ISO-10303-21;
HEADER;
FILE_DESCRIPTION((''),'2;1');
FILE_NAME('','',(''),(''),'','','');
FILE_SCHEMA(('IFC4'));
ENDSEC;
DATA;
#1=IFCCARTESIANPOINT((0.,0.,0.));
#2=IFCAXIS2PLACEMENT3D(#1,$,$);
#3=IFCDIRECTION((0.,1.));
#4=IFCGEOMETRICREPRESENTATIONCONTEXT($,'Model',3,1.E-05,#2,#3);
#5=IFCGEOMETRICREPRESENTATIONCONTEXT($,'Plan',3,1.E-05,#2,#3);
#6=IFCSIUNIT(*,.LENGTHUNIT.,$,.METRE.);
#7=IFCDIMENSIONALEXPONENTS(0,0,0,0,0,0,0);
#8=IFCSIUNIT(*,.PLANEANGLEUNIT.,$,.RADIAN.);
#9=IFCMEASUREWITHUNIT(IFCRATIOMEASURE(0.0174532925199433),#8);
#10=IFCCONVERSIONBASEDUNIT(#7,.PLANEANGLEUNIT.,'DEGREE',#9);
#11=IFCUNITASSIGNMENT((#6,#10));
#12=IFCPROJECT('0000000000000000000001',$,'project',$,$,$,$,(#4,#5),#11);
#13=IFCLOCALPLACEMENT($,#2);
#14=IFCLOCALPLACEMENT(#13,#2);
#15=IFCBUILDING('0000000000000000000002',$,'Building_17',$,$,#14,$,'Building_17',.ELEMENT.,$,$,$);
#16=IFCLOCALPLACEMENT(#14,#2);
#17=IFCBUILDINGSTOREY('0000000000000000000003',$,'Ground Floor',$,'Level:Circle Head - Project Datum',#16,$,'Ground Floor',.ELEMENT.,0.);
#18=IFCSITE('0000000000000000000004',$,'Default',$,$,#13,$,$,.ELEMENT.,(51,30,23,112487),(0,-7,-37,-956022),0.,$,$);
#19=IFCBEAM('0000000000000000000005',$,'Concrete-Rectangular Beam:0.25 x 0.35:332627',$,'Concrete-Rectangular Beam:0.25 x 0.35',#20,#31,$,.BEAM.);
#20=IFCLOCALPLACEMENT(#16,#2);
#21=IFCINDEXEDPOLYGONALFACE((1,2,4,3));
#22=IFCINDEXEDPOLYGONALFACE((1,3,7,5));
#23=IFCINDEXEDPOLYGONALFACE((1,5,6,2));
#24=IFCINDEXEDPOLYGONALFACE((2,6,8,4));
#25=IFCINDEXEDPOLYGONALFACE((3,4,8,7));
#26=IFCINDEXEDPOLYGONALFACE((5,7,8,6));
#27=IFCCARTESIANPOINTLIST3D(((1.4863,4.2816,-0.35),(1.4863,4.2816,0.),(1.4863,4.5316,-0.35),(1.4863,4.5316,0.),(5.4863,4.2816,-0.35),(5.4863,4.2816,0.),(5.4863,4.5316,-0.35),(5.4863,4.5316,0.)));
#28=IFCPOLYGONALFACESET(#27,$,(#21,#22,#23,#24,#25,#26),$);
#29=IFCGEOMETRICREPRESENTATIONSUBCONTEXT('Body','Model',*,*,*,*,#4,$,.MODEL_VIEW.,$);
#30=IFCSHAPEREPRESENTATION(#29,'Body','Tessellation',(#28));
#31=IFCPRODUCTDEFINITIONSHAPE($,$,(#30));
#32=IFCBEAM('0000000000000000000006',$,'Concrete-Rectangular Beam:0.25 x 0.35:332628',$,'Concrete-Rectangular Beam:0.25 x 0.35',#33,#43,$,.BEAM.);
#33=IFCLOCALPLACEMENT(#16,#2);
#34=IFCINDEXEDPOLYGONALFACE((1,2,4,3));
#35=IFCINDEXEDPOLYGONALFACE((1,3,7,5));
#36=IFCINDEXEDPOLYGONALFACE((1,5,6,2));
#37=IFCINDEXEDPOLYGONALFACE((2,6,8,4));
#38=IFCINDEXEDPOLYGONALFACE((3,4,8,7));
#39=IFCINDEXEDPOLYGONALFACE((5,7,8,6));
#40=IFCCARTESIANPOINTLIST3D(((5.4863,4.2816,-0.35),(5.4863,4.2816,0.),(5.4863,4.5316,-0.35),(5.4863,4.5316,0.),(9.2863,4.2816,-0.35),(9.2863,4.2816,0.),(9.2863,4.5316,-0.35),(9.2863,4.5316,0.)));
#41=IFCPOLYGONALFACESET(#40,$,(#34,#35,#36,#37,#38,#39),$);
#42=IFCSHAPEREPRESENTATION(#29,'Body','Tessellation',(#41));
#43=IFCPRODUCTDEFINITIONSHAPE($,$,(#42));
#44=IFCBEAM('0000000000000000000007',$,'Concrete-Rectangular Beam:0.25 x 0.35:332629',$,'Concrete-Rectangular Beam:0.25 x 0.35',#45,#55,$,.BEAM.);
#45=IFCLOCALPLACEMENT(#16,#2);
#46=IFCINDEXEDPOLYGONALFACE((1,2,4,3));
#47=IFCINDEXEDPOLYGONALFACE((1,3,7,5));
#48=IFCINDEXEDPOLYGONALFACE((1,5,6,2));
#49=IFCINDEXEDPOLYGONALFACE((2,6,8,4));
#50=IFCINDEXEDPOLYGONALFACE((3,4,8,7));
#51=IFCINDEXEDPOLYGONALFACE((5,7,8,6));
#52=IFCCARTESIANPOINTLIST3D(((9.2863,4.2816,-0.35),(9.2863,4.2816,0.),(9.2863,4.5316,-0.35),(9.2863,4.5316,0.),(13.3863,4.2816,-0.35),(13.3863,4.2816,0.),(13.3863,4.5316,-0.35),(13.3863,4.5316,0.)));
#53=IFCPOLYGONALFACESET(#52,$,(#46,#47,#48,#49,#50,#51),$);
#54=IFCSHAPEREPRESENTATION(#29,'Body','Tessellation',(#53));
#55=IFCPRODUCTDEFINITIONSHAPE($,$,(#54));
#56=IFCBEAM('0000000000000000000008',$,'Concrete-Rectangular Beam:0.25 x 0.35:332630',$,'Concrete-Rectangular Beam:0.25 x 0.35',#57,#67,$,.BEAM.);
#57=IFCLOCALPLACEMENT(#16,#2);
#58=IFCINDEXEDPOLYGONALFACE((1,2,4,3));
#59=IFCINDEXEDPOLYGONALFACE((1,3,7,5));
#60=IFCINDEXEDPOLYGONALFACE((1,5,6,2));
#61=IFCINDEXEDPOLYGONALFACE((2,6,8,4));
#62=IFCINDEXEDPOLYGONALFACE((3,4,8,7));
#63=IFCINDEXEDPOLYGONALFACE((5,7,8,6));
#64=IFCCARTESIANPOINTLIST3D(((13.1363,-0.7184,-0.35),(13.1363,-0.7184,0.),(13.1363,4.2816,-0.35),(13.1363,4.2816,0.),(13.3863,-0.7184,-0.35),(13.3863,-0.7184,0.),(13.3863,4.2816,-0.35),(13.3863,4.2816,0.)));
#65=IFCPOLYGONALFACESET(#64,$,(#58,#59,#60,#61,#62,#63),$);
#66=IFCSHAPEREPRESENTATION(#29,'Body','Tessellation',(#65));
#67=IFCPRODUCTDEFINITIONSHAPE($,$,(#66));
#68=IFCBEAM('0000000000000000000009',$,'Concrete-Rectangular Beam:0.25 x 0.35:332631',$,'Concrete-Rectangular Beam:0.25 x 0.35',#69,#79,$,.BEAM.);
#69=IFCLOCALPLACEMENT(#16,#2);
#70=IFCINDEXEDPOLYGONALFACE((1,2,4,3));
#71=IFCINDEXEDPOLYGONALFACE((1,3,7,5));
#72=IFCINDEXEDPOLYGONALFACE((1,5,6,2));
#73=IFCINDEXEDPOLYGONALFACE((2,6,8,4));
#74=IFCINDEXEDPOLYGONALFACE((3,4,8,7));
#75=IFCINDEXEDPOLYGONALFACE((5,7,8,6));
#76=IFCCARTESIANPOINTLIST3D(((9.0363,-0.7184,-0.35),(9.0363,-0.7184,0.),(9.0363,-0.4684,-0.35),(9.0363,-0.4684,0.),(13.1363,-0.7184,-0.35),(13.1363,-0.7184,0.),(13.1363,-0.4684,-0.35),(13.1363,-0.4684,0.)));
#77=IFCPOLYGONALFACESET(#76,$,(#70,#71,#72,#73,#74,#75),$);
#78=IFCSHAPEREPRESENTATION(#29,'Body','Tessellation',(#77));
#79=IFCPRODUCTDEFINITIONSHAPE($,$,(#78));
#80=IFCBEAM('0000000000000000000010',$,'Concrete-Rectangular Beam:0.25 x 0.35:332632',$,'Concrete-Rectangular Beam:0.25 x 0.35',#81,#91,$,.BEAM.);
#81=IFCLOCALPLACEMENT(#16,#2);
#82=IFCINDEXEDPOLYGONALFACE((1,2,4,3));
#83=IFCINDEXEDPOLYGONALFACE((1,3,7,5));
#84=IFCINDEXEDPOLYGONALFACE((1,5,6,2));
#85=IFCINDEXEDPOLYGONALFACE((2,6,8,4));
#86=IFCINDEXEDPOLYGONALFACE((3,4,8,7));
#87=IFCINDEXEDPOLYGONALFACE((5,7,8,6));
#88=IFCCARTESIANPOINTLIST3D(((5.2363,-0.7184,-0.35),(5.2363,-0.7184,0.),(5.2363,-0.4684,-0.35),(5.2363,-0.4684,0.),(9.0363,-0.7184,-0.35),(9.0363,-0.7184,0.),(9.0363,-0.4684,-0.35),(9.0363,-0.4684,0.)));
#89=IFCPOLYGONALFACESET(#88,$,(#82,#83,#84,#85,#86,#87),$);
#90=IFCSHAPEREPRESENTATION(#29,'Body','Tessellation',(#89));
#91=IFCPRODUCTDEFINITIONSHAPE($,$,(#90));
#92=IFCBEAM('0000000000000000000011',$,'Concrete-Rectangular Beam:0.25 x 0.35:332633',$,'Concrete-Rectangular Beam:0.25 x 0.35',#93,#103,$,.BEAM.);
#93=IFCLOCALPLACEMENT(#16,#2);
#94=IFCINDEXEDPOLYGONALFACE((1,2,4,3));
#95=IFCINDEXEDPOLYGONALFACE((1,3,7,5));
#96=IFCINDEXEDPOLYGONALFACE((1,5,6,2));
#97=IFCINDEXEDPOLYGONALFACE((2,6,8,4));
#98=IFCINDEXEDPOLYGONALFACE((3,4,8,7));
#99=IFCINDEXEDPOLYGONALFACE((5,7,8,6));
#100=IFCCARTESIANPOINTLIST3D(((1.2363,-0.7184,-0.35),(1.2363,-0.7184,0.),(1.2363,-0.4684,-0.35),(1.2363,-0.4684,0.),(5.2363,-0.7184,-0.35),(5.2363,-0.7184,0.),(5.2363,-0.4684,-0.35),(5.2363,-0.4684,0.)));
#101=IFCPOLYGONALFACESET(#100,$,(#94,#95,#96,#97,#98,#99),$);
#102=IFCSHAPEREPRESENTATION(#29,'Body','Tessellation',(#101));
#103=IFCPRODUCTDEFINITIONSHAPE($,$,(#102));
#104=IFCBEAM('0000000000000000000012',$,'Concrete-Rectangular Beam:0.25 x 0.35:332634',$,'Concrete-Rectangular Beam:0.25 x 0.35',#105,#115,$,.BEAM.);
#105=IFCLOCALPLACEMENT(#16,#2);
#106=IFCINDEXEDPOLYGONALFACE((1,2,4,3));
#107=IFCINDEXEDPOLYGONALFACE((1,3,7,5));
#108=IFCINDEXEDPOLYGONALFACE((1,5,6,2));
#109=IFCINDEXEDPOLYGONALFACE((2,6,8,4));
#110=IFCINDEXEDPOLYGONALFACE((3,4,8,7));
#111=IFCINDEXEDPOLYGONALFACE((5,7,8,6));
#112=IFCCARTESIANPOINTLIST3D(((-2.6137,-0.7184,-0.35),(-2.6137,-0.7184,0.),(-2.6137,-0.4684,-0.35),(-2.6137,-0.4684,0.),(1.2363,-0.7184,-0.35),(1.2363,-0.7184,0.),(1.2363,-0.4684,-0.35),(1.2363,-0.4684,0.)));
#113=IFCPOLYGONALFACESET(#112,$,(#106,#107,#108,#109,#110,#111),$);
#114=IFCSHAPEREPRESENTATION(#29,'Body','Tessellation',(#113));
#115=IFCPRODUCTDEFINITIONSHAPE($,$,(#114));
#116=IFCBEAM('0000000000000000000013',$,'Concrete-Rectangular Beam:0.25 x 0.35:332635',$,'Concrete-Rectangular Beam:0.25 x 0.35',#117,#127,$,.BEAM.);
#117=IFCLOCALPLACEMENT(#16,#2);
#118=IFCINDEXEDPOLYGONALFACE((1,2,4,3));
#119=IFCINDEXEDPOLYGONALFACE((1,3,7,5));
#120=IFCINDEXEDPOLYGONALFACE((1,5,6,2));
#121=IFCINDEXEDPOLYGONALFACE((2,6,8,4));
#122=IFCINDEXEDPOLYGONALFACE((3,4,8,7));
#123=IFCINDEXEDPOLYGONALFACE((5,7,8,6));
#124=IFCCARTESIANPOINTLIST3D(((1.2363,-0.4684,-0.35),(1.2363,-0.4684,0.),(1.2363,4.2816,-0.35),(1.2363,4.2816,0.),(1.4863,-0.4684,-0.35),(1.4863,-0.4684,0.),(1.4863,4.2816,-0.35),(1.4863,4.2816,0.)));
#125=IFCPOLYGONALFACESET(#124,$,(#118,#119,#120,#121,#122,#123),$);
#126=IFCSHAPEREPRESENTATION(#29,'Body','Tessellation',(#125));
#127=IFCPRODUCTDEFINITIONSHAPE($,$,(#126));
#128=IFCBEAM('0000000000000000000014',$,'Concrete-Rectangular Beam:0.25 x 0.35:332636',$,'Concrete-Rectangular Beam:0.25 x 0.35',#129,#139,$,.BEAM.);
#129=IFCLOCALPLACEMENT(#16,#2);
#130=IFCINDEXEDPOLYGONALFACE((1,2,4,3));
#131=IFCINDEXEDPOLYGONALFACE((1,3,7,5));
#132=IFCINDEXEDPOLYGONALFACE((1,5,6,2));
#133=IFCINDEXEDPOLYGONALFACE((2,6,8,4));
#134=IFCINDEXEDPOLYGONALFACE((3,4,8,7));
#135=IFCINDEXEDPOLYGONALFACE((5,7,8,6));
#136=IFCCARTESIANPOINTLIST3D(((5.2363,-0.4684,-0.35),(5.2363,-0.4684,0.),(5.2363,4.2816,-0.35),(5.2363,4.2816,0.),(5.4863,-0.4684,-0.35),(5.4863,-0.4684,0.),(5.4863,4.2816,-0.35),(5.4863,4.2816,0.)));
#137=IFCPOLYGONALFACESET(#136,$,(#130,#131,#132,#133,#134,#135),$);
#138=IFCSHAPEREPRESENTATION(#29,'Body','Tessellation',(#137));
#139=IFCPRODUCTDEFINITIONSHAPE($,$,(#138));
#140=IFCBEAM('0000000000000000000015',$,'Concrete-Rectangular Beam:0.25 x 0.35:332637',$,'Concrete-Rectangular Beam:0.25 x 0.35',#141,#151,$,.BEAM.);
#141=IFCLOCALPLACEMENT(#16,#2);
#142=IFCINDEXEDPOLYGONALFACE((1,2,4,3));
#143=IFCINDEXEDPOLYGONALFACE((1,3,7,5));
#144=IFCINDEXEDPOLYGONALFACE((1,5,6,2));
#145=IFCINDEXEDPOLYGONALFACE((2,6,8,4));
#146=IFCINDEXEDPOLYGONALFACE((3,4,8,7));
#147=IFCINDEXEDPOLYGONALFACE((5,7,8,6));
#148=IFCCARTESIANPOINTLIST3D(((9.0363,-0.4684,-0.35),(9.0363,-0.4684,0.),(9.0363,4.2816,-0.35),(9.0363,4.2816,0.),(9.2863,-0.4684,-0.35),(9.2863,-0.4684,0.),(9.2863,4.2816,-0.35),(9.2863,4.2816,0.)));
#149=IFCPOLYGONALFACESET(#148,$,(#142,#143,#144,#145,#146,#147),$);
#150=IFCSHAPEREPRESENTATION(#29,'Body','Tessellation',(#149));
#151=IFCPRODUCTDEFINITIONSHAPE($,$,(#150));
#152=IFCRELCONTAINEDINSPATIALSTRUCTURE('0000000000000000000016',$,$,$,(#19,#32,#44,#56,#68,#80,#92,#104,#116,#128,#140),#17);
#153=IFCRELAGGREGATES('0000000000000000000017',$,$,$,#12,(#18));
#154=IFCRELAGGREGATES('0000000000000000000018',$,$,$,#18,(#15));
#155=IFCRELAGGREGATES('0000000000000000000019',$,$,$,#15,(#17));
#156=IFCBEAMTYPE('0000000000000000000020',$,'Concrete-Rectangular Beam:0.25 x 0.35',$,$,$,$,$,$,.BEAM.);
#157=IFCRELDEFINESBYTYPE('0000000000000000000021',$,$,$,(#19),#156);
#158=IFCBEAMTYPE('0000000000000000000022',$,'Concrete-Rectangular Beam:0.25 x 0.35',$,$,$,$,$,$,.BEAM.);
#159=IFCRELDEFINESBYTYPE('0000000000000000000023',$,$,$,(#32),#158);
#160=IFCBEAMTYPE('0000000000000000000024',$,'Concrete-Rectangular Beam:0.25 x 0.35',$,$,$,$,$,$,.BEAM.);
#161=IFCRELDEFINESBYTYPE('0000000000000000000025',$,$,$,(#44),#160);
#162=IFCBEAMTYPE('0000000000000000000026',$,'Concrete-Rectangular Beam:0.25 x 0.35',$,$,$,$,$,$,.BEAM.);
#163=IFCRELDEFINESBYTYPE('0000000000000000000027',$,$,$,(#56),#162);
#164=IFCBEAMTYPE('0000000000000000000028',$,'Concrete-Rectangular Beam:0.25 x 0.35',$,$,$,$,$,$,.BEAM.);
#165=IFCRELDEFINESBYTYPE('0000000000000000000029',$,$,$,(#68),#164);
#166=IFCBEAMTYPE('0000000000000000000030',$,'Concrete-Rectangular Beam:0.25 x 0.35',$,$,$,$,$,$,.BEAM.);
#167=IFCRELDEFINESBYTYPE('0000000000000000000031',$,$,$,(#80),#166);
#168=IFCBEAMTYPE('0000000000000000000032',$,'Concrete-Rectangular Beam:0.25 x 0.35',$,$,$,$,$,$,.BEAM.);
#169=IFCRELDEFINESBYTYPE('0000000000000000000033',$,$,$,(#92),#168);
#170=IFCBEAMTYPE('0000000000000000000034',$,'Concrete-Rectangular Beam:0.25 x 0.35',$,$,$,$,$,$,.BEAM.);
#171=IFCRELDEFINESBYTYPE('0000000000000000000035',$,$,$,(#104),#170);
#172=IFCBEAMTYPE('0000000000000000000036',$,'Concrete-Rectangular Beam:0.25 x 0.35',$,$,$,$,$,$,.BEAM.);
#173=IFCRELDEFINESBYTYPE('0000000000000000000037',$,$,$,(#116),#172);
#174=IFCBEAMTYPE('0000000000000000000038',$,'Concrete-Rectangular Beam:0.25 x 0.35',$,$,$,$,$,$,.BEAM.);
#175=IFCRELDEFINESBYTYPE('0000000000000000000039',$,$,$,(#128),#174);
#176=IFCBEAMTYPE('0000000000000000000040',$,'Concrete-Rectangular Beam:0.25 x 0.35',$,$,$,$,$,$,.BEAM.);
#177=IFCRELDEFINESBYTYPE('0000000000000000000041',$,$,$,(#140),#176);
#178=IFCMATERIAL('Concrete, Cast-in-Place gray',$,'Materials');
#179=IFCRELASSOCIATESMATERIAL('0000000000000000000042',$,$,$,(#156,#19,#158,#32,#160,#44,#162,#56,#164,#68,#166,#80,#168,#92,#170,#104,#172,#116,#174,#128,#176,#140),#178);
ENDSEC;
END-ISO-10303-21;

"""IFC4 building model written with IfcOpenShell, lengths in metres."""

from ifc_helpers import new_model, entity, si_unit, converted_unit, direction, frame, origin, place, context, subcontext, project, spatial, indexed_curve, outline, extrude, source, transform, mapped, material, type_object, type_shapes, element, save


model = new_model("IFC4")

# Units and contexts
model_context = context("Model", 3, precision=1e-05, world=origin(), true_north=direction((0.0, 1.0)))
plan_context = context("Plan", 3, precision=1e-05, world=origin(), true_north=direction((0.0, 1.0)))
body_context = subcontext(model_context, "Body", "Model", "MODEL_VIEW")
ifc_project = project(units=[si_unit("LENGTHUNIT", "METRE"), converted_unit("PLANEANGLEUNIT", "DEGREE", entity("IfcRatioMeasure", 0.0174532925199433), si_unit("PLANEANGLEUNIT", "RADIAN"), dimensions=[0, 0, 0, 0, 0, 0, 0])], contexts=[model_context, plan_context])

# Site, building, storey
site_placement = place(None, origin())
site = spatial("IfcSite", under=ifc_project, at=site_placement, Name="Default", CompositionType="ELEMENT", RefLatitude=(51, 30, 23, 112487), RefLongitude=(0, -7, -37, -956022), RefElevation=0.0)
building_placement = place(site_placement, origin())
building = spatial("IfcBuilding", under=site, at=building_placement, Name="Building_17", LongName="Building_17", CompositionType="ELEMENT")
storey_placement = place(building_placement, origin())
storey = spatial("IfcBuildingStorey", under=building, at=storey_placement, Name="Ground Floor", ObjectType="Level:Circle Head - Project Datum", LongName="Ground Floor", CompositionType="ELEMENT", Elevation=0.0)

# Beams
ifc_material_1 = material(Name="Concrete, Cast-in-Place gray", Category="Materials")
beam_type_1 = type_object("IfcBeamType", Name="Concrete-Rectangular Beam:0.25 x 0.35", PredefinedType="BEAM", material=ifc_material_1)
shared_shape_1 = source(origin(), body_context, "Body", "SweptSolid", [
    extrude(outline(indexed_curve([(-0.175, -0.125), (0.175, -0.125), (0.175, 0.125), (-0.175, 0.125), (-0.175, -0.125)], self_intersect=False)), frame((1.4863, 4.4066, -0.175), z_axis=(1.0, 0.0, 0.0), x_axis=(0.0, 0.0, -1.0)), (0.0, 0.0, 1.0), 4.0),
])
type_shapes(beam_type_1, [shared_shape_1])
beam_1_placement = place(storey_placement, origin())
element("IfcBeam", 1, at=beam_1_placement, inside=storey, type_object=beam_type_1, material=ifc_material_1, Name="Concrete-Rectangular Beam:0.25 x 0.35:332627", ObjectType="Concrete-Rectangular Beam:0.25 x 0.35", PredefinedType="BEAM", context=body_context, shape_type="MappedRepresentation", body=[
    mapped(shared_shape_1, transform((0.0, 0.0, 0.0), scale=1.0)),
])
beam_type_2 = type_object("IfcBeamType", Name="Concrete-Rectangular Beam:0.25 x 0.35", PredefinedType="BEAM", material=ifc_material_1)
shared_shape_2 = source(origin(), body_context, "Body", "SweptSolid", [
    extrude(outline(indexed_curve([(-0.175, -0.125), (0.175, -0.125), (0.175, 0.125), (-0.175, 0.125), (-0.175, -0.125)], self_intersect=False)), frame((5.4863, 4.4066, -0.175), z_axis=(1.0, 0.0, 0.0), x_axis=(0.0, 0.0, -1.0)), (0.0, 0.0, 1.0), 3.8),
])
type_shapes(beam_type_2, [shared_shape_2])
beam_2_placement = place(storey_placement, origin())
element("IfcBeam", 2, at=beam_2_placement, inside=storey, type_object=beam_type_2, material=ifc_material_1, Name="Concrete-Rectangular Beam:0.25 x 0.35:332628", ObjectType="Concrete-Rectangular Beam:0.25 x 0.35", PredefinedType="BEAM", context=body_context, shape_type="MappedRepresentation", body=[
    mapped(shared_shape_2, transform((0.0, 0.0, 0.0), scale=1.0)),
])
beam_type_3 = type_object("IfcBeamType", Name="Concrete-Rectangular Beam:0.25 x 0.35", PredefinedType="BEAM", material=ifc_material_1)
shared_shape_3 = source(origin(), body_context, "Body", "SweptSolid", [
    extrude(outline(indexed_curve([(-0.175, -0.125), (0.175, -0.125), (0.175, 0.125), (-0.175, 0.125), (-0.175, -0.125)], self_intersect=False)), frame((9.2863, 4.4066, -0.175), z_axis=(1.0, 0.0, 0.0), x_axis=(0.0, 0.0, -1.0)), (0.0, 0.0, 1.0), 4.1),
])
type_shapes(beam_type_3, [shared_shape_3])
beam_3_placement = place(storey_placement, origin())
element("IfcBeam", 3, at=beam_3_placement, inside=storey, type_object=beam_type_3, material=ifc_material_1, Name="Concrete-Rectangular Beam:0.25 x 0.35:332629", ObjectType="Concrete-Rectangular Beam:0.25 x 0.35", PredefinedType="BEAM", context=body_context, shape_type="MappedRepresentation", body=[
    mapped(shared_shape_3, transform((0.0, 0.0, 0.0), scale=1.0)),
])
beam_type_4 = type_object("IfcBeamType", Name="Concrete-Rectangular Beam:0.25 x 0.35", PredefinedType="BEAM", material=ifc_material_1)
shared_shape_4 = source(origin(), body_context, "Body", "SweptSolid", [
    extrude(outline(indexed_curve([(-0.125, -0.175), (0.125, -0.175), (0.125, 0.175), (-0.125, 0.175), (-0.125, -0.175)], self_intersect=False)), frame((13.2613, 4.2816, -0.175), z_axis=(0.0, -1.0, 0.0), x_axis=(-1.0, 0.0, 0.0)), (0.0, 0.0, 1.0), 5.0),
])
type_shapes(beam_type_4, [shared_shape_4])
beam_4_placement = place(storey_placement, origin())
element("IfcBeam", 4, at=beam_4_placement, inside=storey, type_object=beam_type_4, material=ifc_material_1, Name="Concrete-Rectangular Beam:0.25 x 0.35:332630", ObjectType="Concrete-Rectangular Beam:0.25 x 0.35", PredefinedType="BEAM", context=body_context, shape_type="MappedRepresentation", body=[
    mapped(shared_shape_4, transform((0.0, 0.0, 0.0), scale=1.0)),
])
beam_type_5 = type_object("IfcBeamType", Name="Concrete-Rectangular Beam:0.25 x 0.35", PredefinedType="BEAM", material=ifc_material_1)
shared_shape_5 = source(origin(), body_context, "Body", "SweptSolid", [
    extrude(outline(indexed_curve([(-0.175, -0.125), (0.175, -0.125), (0.175, 0.125), (-0.175, 0.125), (-0.175, -0.125)], self_intersect=False)), frame((13.1363, -0.5934, -0.175), z_axis=(-1.0, 0.0, 0.0), x_axis=(0.0, 0.0, -1.0)), (0.0, 0.0, 1.0), 4.1),
])
type_shapes(beam_type_5, [shared_shape_5])
beam_5_placement = place(storey_placement, origin())
element("IfcBeam", 5, at=beam_5_placement, inside=storey, type_object=beam_type_5, material=ifc_material_1, Name="Concrete-Rectangular Beam:0.25 x 0.35:332631", ObjectType="Concrete-Rectangular Beam:0.25 x 0.35", PredefinedType="BEAM", context=body_context, shape_type="MappedRepresentation", body=[
    mapped(shared_shape_5, transform((0.0, 0.0, 0.0), scale=1.0)),
])
beam_type_6 = type_object("IfcBeamType", Name="Concrete-Rectangular Beam:0.25 x 0.35", PredefinedType="BEAM", material=ifc_material_1)
shared_shape_6 = source(origin(), body_context, "Body", "SweptSolid", [
    extrude(outline(indexed_curve([(-0.175, -0.125), (0.175, -0.125), (0.175, 0.125), (-0.175, 0.125), (-0.175, -0.125)], self_intersect=False)), frame((9.0363, -0.5934, -0.175), z_axis=(-1.0, 0.0, 0.0), x_axis=(0.0, 0.0, -1.0)), (0.0, 0.0, 1.0), 3.8),
])
type_shapes(beam_type_6, [shared_shape_6])
beam_6_placement = place(storey_placement, origin())
element("IfcBeam", 6, at=beam_6_placement, inside=storey, type_object=beam_type_6, material=ifc_material_1, Name="Concrete-Rectangular Beam:0.25 x 0.35:332632", ObjectType="Concrete-Rectangular Beam:0.25 x 0.35", PredefinedType="BEAM", context=body_context, shape_type="MappedRepresentation", body=[
    mapped(shared_shape_6, transform((0.0, 0.0, 0.0), scale=1.0)),
])
beam_type_7 = type_object("IfcBeamType", Name="Concrete-Rectangular Beam:0.25 x 0.35", PredefinedType="BEAM", material=ifc_material_1)
shared_shape_7 = source(origin(), body_context, "Body", "SweptSolid", [
    extrude(outline(indexed_curve([(-0.175, -0.125), (0.175, -0.125), (0.175, 0.125), (-0.175, 0.125), (-0.175, -0.125)], self_intersect=False)), frame((5.2363, -0.5934, -0.175), z_axis=(-1.0, 0.0, 0.0), x_axis=(0.0, 0.0, -1.0)), (0.0, 0.0, 1.0), 4.0),
])
type_shapes(beam_type_7, [shared_shape_7])
beam_7_placement = place(storey_placement, origin())
element("IfcBeam", 7, at=beam_7_placement, inside=storey, type_object=beam_type_7, material=ifc_material_1, Name="Concrete-Rectangular Beam:0.25 x 0.35:332633", ObjectType="Concrete-Rectangular Beam:0.25 x 0.35", PredefinedType="BEAM", context=body_context, shape_type="MappedRepresentation", body=[
    mapped(shared_shape_7, transform((0.0, 0.0, 0.0), scale=1.0)),
])
beam_type_8 = type_object("IfcBeamType", Name="Concrete-Rectangular Beam:0.25 x 0.35", PredefinedType="BEAM", material=ifc_material_1)
shared_shape_8 = source(origin(), body_context, "Body", "SweptSolid", [
    extrude(outline(indexed_curve([(-0.175, -0.125), (0.175, -0.125), (0.175, 0.125), (-0.175, 0.125), (-0.175, -0.125)], self_intersect=False)), frame((1.2363, -0.5934, -0.175), z_axis=(-1.0, 0.0, 0.0), x_axis=(0.0, 0.0, -1.0)), (0.0, 0.0, 1.0), 3.85),
])
type_shapes(beam_type_8, [shared_shape_8])
beam_8_placement = place(storey_placement, origin())
element("IfcBeam", 8, at=beam_8_placement, inside=storey, type_object=beam_type_8, material=ifc_material_1, Name="Concrete-Rectangular Beam:0.25 x 0.35:332634", ObjectType="Concrete-Rectangular Beam:0.25 x 0.35", PredefinedType="BEAM", context=body_context, shape_type="MappedRepresentation", body=[
    mapped(shared_shape_8, transform((0.0, 0.0, 0.0), scale=1.0)),
])
beam_type_9 = type_object("IfcBeamType", Name="Concrete-Rectangular Beam:0.25 x 0.35", PredefinedType="BEAM", material=ifc_material_1)
shared_shape_9 = source(origin(), body_context, "Body", "SweptSolid", [
    extrude(outline(indexed_curve([(-0.125, -0.175), (0.125, -0.175), (0.125, 0.175), (-0.125, 0.175), (-0.125, -0.175)], self_intersect=False)), frame((1.3613, -0.4684, -0.175), z_axis=(0.0, 1.0, 0.0), x_axis=(-1.0, 0.0, 0.0)), (0.0, 0.0, 1.0), 4.75),
])
type_shapes(beam_type_9, [shared_shape_9])
beam_9_placement = place(storey_placement, origin())
element("IfcBeam", 9, at=beam_9_placement, inside=storey, type_object=beam_type_9, material=ifc_material_1, Name="Concrete-Rectangular Beam:0.25 x 0.35:332635", ObjectType="Concrete-Rectangular Beam:0.25 x 0.35", PredefinedType="BEAM", context=body_context, shape_type="MappedRepresentation", body=[
    mapped(shared_shape_9, transform((0.0, 0.0, 0.0), scale=1.0)),
])
beam_type_10 = type_object("IfcBeamType", Name="Concrete-Rectangular Beam:0.25 x 0.35", PredefinedType="BEAM", material=ifc_material_1)
shared_shape_10 = source(origin(), body_context, "Body", "SweptSolid", [
    extrude(outline(indexed_curve([(-0.125, -0.175), (0.125, -0.175), (0.125, 0.175), (-0.125, 0.175), (-0.125, -0.175)], self_intersect=False)), frame((5.3613, 4.2816, -0.175), z_axis=(0.0, -1.0, 0.0), x_axis=(-1.0, 0.0, 0.0)), (0.0, 0.0, 1.0), 4.75),
])
type_shapes(beam_type_10, [shared_shape_10])
beam_10_placement = place(storey_placement, origin())
element("IfcBeam", 10, at=beam_10_placement, inside=storey, type_object=beam_type_10, material=ifc_material_1, Name="Concrete-Rectangular Beam:0.25 x 0.35:332636", ObjectType="Concrete-Rectangular Beam:0.25 x 0.35", PredefinedType="BEAM", context=body_context, shape_type="MappedRepresentation", body=[
    mapped(shared_shape_10, transform((0.0, 0.0, 0.0), scale=1.0)),
])
beam_type_11 = type_object("IfcBeamType", Name="Concrete-Rectangular Beam:0.25 x 0.35", PredefinedType="BEAM", material=ifc_material_1)
shared_shape_11 = source(origin(), body_context, "Body", "SweptSolid", [
    extrude(outline(indexed_curve([(-0.125, -0.175), (0.125, -0.175), (0.125, 0.175), (-0.125, 0.175), (-0.125, -0.175)], self_intersect=False)), frame((9.1613, 4.2816, -0.175), z_axis=(0.0, -1.0, 0.0), x_axis=(-1.0, 0.0, 0.0)), (0.0, 0.0, 1.0), 4.75),
])
type_shapes(beam_type_11, [shared_shape_11])
beam_11_placement = place(storey_placement, origin())
element("IfcBeam", 11, at=beam_11_placement, inside=storey, type_object=beam_type_11, material=ifc_material_1, Name="Concrete-Rectangular Beam:0.25 x 0.35:332637", ObjectType="Concrete-Rectangular Beam:0.25 x 0.35", PredefinedType="BEAM", context=body_context, shape_type="MappedRepresentation", body=[
    mapped(shared_shape_11, transform((0.0, 0.0, 0.0), scale=1.0)),
])

save(model, "model.ifc")
